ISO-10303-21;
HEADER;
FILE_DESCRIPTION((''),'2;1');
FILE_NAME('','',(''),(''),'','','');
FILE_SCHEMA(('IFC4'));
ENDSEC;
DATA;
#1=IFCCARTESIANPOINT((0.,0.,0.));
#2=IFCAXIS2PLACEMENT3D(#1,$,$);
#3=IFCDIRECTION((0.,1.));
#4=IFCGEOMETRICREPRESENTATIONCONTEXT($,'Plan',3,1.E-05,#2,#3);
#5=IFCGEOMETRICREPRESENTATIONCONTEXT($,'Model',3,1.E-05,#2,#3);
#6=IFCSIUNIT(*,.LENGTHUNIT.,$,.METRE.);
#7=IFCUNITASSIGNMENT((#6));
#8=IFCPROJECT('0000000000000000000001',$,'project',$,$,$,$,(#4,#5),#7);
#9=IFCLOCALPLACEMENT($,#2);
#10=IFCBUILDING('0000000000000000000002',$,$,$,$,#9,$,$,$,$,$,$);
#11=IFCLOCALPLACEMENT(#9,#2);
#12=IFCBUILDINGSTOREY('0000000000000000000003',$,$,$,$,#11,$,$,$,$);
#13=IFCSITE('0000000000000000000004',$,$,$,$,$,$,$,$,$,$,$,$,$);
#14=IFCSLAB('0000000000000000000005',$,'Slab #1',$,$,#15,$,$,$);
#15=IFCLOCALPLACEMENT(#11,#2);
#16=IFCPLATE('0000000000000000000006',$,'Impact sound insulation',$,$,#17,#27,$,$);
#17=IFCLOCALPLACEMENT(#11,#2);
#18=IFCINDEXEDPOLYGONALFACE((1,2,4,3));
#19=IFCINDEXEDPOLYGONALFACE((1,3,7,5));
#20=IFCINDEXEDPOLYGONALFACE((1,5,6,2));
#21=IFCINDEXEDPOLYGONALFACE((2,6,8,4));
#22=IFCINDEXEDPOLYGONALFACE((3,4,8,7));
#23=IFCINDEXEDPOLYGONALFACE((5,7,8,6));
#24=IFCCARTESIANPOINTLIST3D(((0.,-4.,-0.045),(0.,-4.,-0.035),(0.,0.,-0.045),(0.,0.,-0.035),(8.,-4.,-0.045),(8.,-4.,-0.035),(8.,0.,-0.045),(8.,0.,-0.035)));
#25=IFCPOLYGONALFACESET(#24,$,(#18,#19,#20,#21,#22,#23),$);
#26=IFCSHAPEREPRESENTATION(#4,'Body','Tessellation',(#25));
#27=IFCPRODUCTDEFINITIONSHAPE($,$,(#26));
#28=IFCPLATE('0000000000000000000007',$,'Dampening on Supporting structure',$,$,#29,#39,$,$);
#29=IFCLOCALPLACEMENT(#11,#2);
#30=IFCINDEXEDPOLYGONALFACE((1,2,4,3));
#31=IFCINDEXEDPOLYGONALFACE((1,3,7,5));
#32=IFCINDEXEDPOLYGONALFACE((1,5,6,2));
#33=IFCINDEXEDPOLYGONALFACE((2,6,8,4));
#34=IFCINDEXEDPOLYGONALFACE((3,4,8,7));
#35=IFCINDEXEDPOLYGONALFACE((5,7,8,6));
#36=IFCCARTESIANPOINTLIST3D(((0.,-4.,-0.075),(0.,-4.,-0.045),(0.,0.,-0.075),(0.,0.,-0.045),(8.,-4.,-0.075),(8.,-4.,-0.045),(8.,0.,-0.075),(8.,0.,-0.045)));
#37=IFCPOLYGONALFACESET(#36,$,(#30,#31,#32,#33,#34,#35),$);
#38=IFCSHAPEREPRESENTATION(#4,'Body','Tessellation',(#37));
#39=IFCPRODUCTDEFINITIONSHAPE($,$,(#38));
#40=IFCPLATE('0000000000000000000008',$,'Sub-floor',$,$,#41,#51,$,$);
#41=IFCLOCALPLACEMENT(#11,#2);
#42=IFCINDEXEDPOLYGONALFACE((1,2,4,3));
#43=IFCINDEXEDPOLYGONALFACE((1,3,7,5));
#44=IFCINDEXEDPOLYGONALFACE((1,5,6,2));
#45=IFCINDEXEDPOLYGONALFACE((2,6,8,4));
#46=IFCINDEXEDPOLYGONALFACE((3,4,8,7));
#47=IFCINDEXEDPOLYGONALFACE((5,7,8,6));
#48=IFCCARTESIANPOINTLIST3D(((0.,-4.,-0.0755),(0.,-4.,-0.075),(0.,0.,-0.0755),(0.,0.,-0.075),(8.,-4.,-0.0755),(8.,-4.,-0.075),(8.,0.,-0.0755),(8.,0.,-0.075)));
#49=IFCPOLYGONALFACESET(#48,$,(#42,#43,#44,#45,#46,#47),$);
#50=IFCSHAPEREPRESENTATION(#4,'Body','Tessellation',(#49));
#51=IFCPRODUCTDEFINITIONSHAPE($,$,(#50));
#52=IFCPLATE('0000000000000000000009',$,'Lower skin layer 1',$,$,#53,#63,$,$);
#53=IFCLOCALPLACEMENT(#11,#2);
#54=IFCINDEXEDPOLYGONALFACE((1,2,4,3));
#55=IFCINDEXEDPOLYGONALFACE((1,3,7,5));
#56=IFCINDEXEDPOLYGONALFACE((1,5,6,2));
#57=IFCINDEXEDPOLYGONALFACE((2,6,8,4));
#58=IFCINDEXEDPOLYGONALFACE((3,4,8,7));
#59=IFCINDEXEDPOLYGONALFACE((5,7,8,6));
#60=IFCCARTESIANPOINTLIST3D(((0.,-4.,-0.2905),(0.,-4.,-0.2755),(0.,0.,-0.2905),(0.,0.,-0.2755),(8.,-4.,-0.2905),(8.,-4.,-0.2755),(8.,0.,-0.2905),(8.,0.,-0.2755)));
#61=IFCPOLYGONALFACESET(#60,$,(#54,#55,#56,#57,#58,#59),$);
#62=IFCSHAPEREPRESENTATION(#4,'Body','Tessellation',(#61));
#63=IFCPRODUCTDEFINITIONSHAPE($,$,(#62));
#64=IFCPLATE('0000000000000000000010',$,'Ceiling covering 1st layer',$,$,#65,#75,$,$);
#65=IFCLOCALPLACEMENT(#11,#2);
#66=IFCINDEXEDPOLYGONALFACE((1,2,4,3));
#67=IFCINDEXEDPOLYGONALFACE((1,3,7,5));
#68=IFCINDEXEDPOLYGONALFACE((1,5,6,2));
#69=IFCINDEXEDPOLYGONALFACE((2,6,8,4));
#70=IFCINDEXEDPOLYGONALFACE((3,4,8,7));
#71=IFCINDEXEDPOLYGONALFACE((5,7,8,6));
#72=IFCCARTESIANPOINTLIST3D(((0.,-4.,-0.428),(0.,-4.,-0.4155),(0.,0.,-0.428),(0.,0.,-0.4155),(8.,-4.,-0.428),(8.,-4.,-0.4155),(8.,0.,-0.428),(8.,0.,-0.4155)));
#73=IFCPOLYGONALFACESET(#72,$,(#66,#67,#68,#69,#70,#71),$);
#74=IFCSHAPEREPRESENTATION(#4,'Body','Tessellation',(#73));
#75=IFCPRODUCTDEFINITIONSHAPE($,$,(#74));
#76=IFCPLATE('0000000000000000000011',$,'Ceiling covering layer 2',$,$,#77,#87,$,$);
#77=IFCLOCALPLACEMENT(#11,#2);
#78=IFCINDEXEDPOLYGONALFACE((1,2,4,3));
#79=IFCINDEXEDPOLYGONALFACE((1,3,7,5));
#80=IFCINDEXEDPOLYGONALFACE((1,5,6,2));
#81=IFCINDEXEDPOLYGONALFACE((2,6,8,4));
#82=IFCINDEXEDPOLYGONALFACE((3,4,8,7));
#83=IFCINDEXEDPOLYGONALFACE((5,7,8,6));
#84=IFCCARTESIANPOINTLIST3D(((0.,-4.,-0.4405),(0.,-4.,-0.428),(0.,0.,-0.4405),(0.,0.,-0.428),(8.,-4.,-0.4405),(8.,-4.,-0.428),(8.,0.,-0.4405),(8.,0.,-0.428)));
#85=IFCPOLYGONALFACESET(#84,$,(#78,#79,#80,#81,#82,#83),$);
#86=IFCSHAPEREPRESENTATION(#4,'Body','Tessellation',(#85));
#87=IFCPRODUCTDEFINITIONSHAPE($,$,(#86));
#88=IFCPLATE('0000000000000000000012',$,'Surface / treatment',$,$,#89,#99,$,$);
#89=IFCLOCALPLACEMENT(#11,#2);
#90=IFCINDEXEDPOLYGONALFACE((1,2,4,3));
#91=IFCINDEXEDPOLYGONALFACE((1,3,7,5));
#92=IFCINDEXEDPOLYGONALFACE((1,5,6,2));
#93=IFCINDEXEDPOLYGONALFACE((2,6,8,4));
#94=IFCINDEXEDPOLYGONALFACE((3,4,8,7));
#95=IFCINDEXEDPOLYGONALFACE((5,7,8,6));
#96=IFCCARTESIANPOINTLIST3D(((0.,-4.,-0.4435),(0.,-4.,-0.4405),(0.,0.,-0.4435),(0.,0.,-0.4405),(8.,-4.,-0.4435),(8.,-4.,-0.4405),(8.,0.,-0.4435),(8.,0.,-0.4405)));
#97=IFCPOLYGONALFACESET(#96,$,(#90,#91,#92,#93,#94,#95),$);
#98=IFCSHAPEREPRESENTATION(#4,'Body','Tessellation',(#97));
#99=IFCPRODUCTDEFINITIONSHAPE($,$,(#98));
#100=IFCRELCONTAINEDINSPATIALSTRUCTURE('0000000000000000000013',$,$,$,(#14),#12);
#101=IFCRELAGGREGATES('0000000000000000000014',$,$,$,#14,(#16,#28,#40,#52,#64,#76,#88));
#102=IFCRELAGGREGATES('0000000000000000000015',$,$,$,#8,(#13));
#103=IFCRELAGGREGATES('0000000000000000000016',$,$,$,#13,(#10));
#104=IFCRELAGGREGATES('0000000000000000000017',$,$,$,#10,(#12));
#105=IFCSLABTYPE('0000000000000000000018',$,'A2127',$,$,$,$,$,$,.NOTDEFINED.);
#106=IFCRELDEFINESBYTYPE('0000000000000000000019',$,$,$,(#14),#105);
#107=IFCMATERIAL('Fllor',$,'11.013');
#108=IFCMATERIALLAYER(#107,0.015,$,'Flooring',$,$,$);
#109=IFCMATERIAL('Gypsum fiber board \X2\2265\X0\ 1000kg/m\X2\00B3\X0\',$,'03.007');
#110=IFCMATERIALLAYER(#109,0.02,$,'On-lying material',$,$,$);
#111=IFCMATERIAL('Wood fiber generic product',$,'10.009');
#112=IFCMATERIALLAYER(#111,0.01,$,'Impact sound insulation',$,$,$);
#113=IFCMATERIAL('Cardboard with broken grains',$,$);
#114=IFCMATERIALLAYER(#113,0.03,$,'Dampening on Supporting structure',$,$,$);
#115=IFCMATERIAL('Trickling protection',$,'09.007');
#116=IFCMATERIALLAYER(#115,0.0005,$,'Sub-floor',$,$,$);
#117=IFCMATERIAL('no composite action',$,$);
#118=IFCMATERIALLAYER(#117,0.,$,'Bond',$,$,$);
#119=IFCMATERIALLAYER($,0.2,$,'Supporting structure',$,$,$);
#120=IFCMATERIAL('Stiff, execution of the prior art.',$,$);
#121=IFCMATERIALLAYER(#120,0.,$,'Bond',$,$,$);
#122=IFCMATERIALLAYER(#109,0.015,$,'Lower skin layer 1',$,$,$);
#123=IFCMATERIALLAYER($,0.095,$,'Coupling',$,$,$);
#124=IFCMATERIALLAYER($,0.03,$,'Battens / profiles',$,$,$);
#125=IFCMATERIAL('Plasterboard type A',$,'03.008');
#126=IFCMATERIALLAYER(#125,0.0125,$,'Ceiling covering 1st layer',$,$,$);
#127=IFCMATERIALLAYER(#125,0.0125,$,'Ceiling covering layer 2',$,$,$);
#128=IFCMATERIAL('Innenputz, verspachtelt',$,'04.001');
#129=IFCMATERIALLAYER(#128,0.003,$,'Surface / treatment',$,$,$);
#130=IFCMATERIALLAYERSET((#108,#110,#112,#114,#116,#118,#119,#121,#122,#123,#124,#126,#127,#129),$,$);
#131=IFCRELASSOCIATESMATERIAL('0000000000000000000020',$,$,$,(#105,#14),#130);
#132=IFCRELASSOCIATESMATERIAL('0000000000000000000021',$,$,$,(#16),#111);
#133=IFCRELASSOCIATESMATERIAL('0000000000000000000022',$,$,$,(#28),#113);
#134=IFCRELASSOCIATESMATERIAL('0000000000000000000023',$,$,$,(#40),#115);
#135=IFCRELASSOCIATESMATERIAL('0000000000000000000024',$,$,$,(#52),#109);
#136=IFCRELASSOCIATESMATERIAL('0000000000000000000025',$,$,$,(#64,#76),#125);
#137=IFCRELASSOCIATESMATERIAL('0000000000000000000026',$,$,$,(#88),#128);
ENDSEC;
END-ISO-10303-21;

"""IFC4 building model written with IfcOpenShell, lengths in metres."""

from ifc_helpers import new_model, si_unit, direction, frame, frame_2d, origin, place, context, project, spatial, rectangle, extrude, material, layer, layer_set, type_object, element, aggregate, save


model = new_model("IFC4")

# Units and contexts
plan_context = context("Plan", 3, precision=1e-05, world=origin(), true_north=direction((0.0, 1.0)))
model_context = context("Model", 3, precision=1e-05, world=origin(), true_north=direction((0.0, 1.0)))
ifc_project = project(units=[si_unit("LENGTHUNIT", "METRE")], contexts=[plan_context, model_context])

# Site, building, storey
site = spatial("IfcSite", under=ifc_project)
building_placement = place(None, origin())
building = spatial("IfcBuilding", under=site, at=building_placement)
storey_placement = place(building_placement, origin())
storey = spatial("IfcBuildingStorey", under=building, at=storey_placement)

# Slab, plates
ifc_material_1 = material(Name="Fllor", Category="11.013")
ifc_layer_1 = layer(ifc_material_1, 0.015, Name="Flooring")
ifc_material_2 = material(Name="Gypsum fiber board ≥ 1000kg/m³", Category="03.007")
ifc_layer_2 = layer(ifc_material_2, 0.02, Name="On-lying material")
ifc_material_3 = material(Name="Wood fiber generic product", Category="10.009")
ifc_layer_3 = layer(ifc_material_3, 0.01, Name="Impact sound insulation")
ifc_material_4 = material(Name="Cardboard with broken grains")
ifc_layer_4 = layer(ifc_material_4, 0.03, Name="Dampening on Supporting structure")
ifc_material_5 = material(Name="Trickling protection", Category="09.007")
ifc_layer_5 = layer(ifc_material_5, 0.0005, Name="Sub-floor")
ifc_material_6 = material(Name="no composite action")
ifc_layer_6 = layer(ifc_material_6, 0.0, Name="Bond")
ifc_layer_7 = layer(None, 0.2, Name="Supporting structure")
ifc_material_7 = material(Name="Stiff, execution of the prior art.")
ifc_layer_8 = layer(ifc_material_7, 0.0, Name="Bond")
ifc_layer_9 = layer(ifc_material_2, 0.015, Name="Lower skin layer 1")
ifc_layer_10 = layer(None, 0.095, Name="Coupling")
ifc_layer_11 = layer(None, 0.03, Name="Battens / profiles")
ifc_material_8 = material(Name="Plasterboard type A", Category="03.008")
ifc_layer_12 = layer(ifc_material_8, 0.0125, Name="Ceiling covering 1st layer")
ifc_layer_13 = layer(ifc_material_8, 0.0125, Name="Ceiling covering layer 2")
ifc_material_9 = material(Name="Innenputz, verspachtelt", Category="04.001")
ifc_layer_14 = layer(ifc_material_9, 0.003, Name="Surface / treatment")
ifc_layer_set = layer_set([ifc_layer_1, ifc_layer_2, ifc_layer_3, ifc_layer_4, ifc_layer_5, ifc_layer_6, ifc_layer_7, ifc_layer_8, ifc_layer_9, ifc_layer_10, ifc_layer_11, ifc_layer_12, ifc_layer_13, ifc_layer_14])
slab_type = type_object("IfcSlabType", Name="A2127", PredefinedType="NOTDEFINED", material=ifc_layer_set)
slab_placement = place(None, frame((0.0, 0.0, 0.0), z_axis=(0.0, 0.0, -1.0), x_axis=(1.0, 0.0, 0.0)))
slab = element("IfcSlab", 1, at=slab_placement, inside=storey, type_object=slab_type, material=ifc_layer_set, Name="Slab #1")
plate_1_placement = place(slab_placement, origin())
plate_1 = element("IfcPlate", 2, at=plate_1_placement, material=ifc_material_3, Name="Impact sound insulation", context=plan_context, shape_type="SweptSolid", body=[
    extrude(rectangle(XDim=8.0, YDim=4.0, at=frame_2d((4.0, 2.0), x_axis=(1.0, 0.0))), frame((0.0, 0.0, 0.035), z_axis=(0.0, 0.0, 1.0), x_axis=(1.0, 0.0, 0.0)), (0.0, 0.0, 1.0), 0.01),
])
plate_2_placement = place(slab_placement, origin())
plate_2 = element("IfcPlate", 3, at=plate_2_placement, material=ifc_material_4, Name="Dampening on Supporting structure", context=plan_context, shape_type="SweptSolid", body=[
    extrude(rectangle(XDim=8.0, YDim=4.0, at=frame_2d((4.0, 2.0), x_axis=(1.0, 0.0))), frame((0.0, 0.0, 0.045), z_axis=(0.0, 0.0, 1.0), x_axis=(1.0, 0.0, 0.0)), (0.0, 0.0, 1.0), 0.03),
])
plate_3_placement = place(slab_placement, origin())
plate_3 = element("IfcPlate", 4, at=plate_3_placement, material=ifc_material_5, Name="Sub-floor", context=plan_context, shape_type="SweptSolid", body=[
    extrude(rectangle(XDim=8.0, YDim=4.0, at=frame_2d((4.0, 2.0), x_axis=(1.0, 0.0))), frame((0.0, 0.0, 0.075), z_axis=(0.0, 0.0, 1.0), x_axis=(1.0, 0.0, 0.0)), (0.0, 0.0, 1.0), 0.0005),
])
plate_4_placement = place(slab_placement, origin())
plate_4 = element("IfcPlate", 5, at=plate_4_placement, material=ifc_material_2, Name="Lower skin layer 1", context=plan_context, shape_type="SweptSolid", body=[
    extrude(rectangle(XDim=8.0, YDim=4.0, at=frame_2d((4.0, 2.0), x_axis=(1.0, 0.0))), frame((0.0, 0.0, 0.2755), z_axis=(0.0, 0.0, 1.0), x_axis=(1.0, 0.0, 0.0)), (0.0, 0.0, 1.0), 0.015),
])
plate_5_placement = place(slab_placement, origin())
plate_5 = element("IfcPlate", 6, at=plate_5_placement, material=ifc_material_8, Name="Ceiling covering 1st layer", context=plan_context, shape_type="SweptSolid", body=[
    extrude(rectangle(XDim=8.0, YDim=4.0, at=frame_2d((4.0, 2.0), x_axis=(1.0, 0.0))), frame((0.0, 0.0, 0.4155), z_axis=(0.0, 0.0, 1.0), x_axis=(1.0, 0.0, 0.0)), (0.0, 0.0, 1.0), 0.0125),
])
plate_6_placement = place(slab_placement, origin())
plate_6 = element("IfcPlate", 7, at=plate_6_placement, material=ifc_material_8, Name="Ceiling covering layer 2", context=plan_context, shape_type="SweptSolid", body=[
    extrude(rectangle(XDim=8.0, YDim=4.0, at=frame_2d((4.0, 2.0), x_axis=(1.0, 0.0))), frame((0.0, 0.0, 0.428), z_axis=(0.0, 0.0, 1.0), x_axis=(1.0, 0.0, 0.0)), (0.0, 0.0, 1.0), 0.0125),
])
plate_7_placement = place(slab_placement, origin())
plate_7 = element("IfcPlate", 8, at=plate_7_placement, material=ifc_material_9, Name="Surface / treatment", context=plan_context, shape_type="SweptSolid", body=[
    extrude(rectangle(XDim=8.0, YDim=4.0, at=frame_2d((4.0, 2.0), x_axis=(1.0, 0.0))), frame((0.0, 0.0, 0.4405), z_axis=(0.0, 0.0, 1.0), x_axis=(1.0, 0.0, 0.0)), (0.0, 0.0, 1.0), 0.003),
])
aggregate(slab, [plate_1, plate_2, plate_3, plate_4, plate_5, plate_6, plate_7])

save(model, "model.ifc")
